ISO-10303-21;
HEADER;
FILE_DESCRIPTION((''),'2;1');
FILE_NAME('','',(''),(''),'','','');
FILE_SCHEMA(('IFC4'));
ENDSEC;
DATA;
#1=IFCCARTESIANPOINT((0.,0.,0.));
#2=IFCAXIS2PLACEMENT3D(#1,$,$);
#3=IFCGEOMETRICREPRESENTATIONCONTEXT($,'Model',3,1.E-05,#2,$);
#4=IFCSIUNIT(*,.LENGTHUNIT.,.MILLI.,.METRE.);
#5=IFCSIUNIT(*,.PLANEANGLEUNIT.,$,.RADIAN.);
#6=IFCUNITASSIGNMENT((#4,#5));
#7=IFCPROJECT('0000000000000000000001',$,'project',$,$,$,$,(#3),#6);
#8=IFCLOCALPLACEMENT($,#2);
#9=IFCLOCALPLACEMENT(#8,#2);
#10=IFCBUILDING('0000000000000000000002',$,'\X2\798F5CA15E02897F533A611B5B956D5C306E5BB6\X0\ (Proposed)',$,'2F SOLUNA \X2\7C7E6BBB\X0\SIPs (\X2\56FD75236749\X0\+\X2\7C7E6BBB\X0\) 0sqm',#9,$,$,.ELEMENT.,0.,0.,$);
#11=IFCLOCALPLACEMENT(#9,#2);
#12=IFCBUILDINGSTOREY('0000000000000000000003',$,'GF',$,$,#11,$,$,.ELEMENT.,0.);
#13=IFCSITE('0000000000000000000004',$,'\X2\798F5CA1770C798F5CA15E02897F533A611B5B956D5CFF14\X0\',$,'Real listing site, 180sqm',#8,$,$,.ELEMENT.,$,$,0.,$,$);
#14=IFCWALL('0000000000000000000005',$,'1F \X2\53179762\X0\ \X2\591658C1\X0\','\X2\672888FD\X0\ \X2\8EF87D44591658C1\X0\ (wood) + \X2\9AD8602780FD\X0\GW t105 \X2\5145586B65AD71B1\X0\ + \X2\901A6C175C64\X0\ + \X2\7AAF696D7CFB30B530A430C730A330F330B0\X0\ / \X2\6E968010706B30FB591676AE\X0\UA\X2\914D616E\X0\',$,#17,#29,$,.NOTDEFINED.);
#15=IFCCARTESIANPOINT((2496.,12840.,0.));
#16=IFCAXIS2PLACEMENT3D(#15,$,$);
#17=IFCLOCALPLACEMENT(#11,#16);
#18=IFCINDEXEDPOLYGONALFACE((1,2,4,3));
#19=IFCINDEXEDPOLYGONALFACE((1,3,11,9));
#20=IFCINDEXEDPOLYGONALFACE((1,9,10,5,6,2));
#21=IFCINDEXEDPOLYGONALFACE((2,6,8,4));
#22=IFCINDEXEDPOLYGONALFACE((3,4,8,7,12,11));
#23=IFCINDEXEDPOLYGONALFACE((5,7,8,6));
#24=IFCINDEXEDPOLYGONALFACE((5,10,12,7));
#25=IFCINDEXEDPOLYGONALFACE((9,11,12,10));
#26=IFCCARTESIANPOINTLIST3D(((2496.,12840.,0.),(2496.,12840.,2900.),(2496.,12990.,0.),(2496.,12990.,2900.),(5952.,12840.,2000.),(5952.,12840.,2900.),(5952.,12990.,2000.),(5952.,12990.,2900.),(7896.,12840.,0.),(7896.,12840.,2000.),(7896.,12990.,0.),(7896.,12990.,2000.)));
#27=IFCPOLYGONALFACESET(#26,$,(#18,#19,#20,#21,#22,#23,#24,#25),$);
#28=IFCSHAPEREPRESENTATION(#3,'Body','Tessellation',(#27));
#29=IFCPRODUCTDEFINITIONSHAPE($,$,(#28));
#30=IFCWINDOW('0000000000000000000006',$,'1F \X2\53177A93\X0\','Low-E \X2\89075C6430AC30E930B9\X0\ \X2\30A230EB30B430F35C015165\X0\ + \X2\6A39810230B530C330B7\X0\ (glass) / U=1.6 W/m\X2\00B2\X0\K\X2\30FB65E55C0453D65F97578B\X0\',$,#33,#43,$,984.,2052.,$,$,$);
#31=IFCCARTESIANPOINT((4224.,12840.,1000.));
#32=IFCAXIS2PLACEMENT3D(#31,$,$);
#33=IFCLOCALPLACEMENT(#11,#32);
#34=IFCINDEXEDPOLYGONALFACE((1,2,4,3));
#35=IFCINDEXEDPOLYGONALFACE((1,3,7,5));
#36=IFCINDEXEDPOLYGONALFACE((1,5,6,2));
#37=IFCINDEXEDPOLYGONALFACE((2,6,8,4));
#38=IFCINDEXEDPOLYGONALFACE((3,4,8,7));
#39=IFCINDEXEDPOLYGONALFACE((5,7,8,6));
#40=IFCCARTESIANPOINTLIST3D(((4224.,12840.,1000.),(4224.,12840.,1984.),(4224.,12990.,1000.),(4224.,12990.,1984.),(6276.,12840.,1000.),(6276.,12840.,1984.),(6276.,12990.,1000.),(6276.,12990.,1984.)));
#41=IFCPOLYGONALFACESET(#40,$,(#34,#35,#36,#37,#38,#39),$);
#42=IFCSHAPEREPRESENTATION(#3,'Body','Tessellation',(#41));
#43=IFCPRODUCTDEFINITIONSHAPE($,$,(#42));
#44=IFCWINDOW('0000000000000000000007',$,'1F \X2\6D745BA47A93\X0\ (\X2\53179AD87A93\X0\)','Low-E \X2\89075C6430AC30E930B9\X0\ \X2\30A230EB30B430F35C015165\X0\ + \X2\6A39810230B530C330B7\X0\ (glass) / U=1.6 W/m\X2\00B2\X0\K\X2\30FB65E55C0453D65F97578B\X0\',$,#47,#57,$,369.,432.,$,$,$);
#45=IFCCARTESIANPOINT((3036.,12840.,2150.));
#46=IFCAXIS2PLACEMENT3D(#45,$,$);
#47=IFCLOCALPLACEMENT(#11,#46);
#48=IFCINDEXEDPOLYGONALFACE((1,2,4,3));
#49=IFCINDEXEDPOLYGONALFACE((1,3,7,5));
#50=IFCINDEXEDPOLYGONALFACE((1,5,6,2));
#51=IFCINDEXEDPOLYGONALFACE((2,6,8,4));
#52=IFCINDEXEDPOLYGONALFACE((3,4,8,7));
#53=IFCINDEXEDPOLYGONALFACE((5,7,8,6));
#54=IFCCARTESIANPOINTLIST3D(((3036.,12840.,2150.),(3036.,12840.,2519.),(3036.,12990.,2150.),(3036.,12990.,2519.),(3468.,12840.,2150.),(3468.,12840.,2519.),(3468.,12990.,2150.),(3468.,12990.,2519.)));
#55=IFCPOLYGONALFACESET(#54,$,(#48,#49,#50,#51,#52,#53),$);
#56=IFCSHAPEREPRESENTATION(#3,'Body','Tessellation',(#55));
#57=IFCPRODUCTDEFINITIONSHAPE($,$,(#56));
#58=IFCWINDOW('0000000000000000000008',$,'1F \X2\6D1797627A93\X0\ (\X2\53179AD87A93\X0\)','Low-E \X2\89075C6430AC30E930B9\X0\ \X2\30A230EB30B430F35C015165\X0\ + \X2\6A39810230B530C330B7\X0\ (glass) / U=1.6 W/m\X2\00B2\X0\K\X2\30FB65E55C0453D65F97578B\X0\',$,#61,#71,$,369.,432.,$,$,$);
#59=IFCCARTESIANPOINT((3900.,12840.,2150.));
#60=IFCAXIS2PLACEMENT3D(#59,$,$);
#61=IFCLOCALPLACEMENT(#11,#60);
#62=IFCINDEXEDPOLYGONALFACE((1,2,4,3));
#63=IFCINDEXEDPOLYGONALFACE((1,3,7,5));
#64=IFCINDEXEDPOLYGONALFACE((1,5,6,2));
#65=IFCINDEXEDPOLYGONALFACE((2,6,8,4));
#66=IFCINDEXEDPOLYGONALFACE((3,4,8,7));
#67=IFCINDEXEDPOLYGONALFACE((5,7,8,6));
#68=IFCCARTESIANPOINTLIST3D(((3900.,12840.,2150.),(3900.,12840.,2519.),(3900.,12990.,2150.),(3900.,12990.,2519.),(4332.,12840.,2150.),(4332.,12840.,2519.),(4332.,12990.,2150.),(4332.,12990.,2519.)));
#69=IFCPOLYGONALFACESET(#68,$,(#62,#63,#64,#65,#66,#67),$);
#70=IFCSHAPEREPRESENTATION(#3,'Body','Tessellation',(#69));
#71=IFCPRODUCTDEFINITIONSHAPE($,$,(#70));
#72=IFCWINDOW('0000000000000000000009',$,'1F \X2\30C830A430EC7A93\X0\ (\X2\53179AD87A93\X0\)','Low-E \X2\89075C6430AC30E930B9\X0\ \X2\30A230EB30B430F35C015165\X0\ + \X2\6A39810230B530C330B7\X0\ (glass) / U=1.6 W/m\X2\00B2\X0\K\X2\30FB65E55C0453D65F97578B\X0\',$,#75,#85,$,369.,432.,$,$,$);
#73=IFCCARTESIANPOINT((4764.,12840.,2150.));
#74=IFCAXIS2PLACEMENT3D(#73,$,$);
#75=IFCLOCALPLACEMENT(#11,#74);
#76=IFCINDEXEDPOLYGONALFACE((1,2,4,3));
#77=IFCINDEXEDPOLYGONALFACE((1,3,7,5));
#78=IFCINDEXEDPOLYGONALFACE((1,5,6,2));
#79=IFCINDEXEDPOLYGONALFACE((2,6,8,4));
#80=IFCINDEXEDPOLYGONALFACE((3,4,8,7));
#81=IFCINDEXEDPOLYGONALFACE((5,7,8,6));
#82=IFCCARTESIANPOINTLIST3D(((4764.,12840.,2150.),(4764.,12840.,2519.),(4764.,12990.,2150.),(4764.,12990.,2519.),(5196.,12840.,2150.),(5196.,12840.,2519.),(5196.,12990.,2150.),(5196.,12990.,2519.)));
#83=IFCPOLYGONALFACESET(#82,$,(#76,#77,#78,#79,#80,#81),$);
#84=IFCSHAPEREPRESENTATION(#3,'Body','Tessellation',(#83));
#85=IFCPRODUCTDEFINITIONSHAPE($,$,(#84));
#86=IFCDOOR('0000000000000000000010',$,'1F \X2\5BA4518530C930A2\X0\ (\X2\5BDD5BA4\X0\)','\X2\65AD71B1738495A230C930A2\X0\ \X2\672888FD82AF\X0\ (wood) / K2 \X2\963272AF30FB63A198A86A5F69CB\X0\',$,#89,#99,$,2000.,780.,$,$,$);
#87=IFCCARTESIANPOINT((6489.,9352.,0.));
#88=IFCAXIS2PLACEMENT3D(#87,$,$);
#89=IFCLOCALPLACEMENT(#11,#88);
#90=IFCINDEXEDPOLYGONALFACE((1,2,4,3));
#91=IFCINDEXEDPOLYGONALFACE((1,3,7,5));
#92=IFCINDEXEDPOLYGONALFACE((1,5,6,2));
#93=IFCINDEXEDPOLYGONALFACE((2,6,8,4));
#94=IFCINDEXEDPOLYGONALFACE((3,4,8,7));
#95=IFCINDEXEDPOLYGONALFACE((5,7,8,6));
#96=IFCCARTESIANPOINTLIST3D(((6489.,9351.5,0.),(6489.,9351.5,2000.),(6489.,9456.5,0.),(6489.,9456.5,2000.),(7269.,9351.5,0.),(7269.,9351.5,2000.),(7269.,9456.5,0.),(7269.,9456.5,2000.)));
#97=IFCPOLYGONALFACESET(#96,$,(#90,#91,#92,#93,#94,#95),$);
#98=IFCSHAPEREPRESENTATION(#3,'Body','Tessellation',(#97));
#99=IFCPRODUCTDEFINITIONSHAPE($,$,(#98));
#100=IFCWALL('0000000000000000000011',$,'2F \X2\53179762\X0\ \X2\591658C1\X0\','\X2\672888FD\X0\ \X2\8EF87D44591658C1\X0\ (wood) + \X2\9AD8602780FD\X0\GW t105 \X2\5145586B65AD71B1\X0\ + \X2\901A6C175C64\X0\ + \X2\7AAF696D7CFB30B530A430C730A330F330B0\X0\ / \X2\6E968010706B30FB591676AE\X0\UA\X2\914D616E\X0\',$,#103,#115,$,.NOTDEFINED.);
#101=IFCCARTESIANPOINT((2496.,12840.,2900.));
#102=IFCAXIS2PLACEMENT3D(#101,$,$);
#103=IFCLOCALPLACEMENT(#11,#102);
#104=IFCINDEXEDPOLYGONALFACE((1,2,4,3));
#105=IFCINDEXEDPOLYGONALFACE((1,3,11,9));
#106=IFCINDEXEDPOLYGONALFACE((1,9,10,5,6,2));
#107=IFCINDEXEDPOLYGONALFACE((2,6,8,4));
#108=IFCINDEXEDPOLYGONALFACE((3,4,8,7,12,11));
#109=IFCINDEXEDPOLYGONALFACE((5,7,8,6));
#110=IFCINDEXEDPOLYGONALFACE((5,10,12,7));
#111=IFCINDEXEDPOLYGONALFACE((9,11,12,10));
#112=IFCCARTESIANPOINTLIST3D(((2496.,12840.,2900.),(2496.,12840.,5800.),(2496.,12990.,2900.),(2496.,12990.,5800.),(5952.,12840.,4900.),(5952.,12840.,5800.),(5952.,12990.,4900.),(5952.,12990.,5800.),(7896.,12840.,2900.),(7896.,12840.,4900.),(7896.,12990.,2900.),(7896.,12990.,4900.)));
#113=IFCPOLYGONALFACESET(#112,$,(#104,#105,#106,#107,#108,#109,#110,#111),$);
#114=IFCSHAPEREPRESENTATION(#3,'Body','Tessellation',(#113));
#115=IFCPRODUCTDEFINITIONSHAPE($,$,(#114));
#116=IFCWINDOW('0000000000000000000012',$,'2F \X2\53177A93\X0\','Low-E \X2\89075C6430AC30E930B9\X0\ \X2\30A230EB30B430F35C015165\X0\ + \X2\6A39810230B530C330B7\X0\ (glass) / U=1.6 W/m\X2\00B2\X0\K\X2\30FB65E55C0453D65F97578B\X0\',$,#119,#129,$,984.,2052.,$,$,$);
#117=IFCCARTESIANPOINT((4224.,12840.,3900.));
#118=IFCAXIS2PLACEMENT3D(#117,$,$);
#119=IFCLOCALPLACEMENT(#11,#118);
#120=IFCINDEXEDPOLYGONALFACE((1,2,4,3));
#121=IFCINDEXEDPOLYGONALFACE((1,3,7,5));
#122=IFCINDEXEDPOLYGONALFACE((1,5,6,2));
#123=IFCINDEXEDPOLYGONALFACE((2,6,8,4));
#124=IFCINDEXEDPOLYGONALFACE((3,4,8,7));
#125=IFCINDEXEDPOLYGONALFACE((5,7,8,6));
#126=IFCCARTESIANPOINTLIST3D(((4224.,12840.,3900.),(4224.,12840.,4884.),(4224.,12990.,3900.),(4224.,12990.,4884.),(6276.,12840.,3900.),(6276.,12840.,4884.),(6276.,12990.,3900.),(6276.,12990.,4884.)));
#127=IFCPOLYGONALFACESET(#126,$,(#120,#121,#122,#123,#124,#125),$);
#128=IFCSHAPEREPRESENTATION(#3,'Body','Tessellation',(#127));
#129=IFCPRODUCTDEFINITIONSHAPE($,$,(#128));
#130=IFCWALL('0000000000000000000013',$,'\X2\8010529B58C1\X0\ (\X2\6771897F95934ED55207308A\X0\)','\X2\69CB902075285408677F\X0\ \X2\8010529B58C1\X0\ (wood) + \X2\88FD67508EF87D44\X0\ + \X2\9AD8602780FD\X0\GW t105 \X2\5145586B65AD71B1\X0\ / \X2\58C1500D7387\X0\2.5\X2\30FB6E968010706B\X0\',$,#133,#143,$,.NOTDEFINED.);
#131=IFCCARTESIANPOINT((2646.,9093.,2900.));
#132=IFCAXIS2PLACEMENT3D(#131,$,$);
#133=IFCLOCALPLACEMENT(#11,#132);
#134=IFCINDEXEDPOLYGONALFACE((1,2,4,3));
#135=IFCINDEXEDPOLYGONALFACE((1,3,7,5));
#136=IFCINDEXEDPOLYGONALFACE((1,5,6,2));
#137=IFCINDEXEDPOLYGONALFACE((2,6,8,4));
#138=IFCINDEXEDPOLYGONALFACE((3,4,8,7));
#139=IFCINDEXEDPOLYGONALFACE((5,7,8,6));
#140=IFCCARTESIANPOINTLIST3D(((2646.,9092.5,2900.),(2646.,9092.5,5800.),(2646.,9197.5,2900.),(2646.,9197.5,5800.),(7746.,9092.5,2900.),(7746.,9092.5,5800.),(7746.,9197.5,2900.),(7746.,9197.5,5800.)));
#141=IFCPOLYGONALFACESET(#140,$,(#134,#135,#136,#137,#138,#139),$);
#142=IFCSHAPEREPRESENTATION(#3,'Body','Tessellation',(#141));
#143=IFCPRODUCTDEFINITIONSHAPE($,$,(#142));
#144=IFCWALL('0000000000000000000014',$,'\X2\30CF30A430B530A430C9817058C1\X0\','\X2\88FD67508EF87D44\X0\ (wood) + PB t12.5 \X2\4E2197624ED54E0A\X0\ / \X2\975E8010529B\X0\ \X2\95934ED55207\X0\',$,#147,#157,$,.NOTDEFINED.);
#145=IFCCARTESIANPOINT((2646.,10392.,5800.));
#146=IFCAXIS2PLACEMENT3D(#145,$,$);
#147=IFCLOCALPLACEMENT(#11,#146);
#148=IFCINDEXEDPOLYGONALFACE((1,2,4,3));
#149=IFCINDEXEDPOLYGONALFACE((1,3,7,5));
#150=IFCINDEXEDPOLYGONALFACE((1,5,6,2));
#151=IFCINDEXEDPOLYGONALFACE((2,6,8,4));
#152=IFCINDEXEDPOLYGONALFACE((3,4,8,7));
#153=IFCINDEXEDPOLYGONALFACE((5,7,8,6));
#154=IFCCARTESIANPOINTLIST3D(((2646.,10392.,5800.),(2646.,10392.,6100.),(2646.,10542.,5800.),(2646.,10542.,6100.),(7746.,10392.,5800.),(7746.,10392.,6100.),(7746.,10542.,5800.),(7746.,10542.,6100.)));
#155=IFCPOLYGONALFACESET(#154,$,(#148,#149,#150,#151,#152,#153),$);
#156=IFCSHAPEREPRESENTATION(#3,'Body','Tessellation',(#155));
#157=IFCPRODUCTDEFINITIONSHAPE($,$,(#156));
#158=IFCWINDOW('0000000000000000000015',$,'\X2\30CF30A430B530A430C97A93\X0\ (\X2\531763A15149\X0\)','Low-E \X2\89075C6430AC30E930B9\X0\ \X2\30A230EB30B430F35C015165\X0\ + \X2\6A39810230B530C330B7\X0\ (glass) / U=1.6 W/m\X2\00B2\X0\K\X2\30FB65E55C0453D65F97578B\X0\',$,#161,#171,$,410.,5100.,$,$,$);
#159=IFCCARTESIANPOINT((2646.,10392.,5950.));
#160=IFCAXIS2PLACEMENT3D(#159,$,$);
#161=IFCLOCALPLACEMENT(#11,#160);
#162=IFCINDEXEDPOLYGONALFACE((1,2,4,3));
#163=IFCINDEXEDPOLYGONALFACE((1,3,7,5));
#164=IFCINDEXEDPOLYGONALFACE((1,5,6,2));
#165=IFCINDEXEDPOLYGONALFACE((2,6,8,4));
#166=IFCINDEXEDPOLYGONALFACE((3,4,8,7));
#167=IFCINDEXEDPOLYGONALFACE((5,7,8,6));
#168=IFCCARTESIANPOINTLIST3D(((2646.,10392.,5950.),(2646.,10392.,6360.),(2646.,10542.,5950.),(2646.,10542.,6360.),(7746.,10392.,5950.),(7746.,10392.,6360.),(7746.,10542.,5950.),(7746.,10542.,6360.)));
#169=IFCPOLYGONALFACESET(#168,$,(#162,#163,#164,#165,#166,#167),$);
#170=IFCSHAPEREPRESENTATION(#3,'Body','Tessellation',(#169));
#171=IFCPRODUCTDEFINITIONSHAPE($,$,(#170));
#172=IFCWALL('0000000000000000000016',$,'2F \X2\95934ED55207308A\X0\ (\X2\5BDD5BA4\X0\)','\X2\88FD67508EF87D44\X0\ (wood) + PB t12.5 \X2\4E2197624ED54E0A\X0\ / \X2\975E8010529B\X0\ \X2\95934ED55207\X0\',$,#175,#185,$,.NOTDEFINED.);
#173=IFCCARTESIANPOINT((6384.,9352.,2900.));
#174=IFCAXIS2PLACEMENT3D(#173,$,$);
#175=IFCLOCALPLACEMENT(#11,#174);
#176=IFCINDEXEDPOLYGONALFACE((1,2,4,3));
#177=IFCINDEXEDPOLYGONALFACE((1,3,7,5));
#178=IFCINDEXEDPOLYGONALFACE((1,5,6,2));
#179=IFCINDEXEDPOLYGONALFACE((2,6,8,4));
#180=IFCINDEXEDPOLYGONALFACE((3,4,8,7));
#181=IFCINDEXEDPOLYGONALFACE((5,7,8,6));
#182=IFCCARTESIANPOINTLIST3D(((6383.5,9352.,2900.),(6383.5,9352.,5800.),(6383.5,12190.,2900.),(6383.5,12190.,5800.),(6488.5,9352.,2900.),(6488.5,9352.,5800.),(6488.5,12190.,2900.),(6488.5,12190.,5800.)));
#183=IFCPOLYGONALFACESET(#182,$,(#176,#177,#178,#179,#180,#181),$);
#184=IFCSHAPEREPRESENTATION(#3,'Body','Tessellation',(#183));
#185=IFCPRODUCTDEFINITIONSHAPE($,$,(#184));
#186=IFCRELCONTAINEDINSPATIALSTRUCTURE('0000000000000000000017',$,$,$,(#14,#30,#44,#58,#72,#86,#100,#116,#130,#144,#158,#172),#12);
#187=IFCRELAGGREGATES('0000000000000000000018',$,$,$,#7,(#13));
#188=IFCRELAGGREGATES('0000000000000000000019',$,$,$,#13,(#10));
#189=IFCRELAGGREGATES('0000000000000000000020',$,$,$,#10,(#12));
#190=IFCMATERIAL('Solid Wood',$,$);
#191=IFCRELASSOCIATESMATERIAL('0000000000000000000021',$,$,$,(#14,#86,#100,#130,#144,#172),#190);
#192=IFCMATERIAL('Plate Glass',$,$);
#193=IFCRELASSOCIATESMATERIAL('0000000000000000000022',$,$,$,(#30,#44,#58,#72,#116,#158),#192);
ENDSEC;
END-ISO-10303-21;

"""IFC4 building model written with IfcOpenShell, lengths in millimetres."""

from ifc_helpers import new_model, si_unit, frame, frame_2d, origin, place, context, project, spatial, rectangle, extrude, material, element, fill, save


model = new_model("IFC4")

# Units and contexts
model_context = context("Model", 3, precision=1e-05, world=origin())
ifc_project = project(units=[si_unit("LENGTHUNIT", "METRE", prefix="MILLI"), si_unit("PLANEANGLEUNIT", "RADIAN")], contexts=[model_context])

# Site, building, storey
site_placement = place(None, origin())
site = spatial("IfcSite", under=ifc_project, at=site_placement, Name="福岡県福岡市西区愛宕浜４", ObjectType="Real listing site, 180sqm", CompositionType="ELEMENT", RefElevation=0.0)
building_placement = place(site_placement, origin())
building = spatial("IfcBuilding", under=site, at=building_placement, Name="福岡市西区愛宕浜の家 (Proposed)", ObjectType="2F SOLUNA 籾殻SIPs (国産杉+籾殻) 0sqm", CompositionType="ELEMENT", ElevationOfRefHeight=0.0, ElevationOfTerrain=0.0)
storey_placement = place(building_placement, origin())
storey = spatial("IfcBuildingStorey", under=building, at=storey_placement, Name="GF", CompositionType="ELEMENT", Elevation=0.0)

# Wall, openings, windows
ifc_material_1 = material(Name="Solid Wood")
wall_1_placement = place(storey_placement, frame((2496.0, 12840.0, 0.0)))
wall_1 = element("IfcWall", 1, at=wall_1_placement, inside=storey, material=ifc_material_1, Name="1F 北面 外壁", Description="木製 軸組外壁 (wood) + 高性能GW t105 充填断熱 + 通気層 + 窯業系サイディング / 準耐火・外皮UA配慮", PredefinedType="NOTDEFINED", context=model_context, shape_type="SweptSolid", body=[
    extrude(rectangle(XDim=5400.0, YDim=150.0, at=frame_2d((2700.0, 75.0))), frame((2496.0, 12840.0, 0.0)), (0.0, 0.0, 1.0), 2900.0),
])
opening_1_placement = place(storey_placement, frame((4224.0, 12840.0, 1000.0)))
opening_1 = element("IfcOpeningElement", 2, at=opening_1_placement, cuts=wall_1, PredefinedType="NOTDEFINED", context=model_context, shape_type="SweptSolid", body=[
    extrude(rectangle(XDim=2052.0, YDim=150.0, at=frame_2d((1026.0, 75.0))), frame((4224.0, 12840.0, 1000.0)), (0.0, 0.0, 1.0), 984.0),
])
opening_2_placement = place(storey_placement, frame((3036.0, 12840.0, 2150.0)))
opening_2 = element("IfcOpeningElement", 3, at=opening_2_placement, cuts=wall_1, PredefinedType="NOTDEFINED", context=model_context, shape_type="SweptSolid", body=[
    extrude(rectangle(XDim=432.0, YDim=150.0, at=frame_2d((216.0, 75.0))), frame((3036.0, 12840.0, 2150.0)), (0.0, 0.0, 1.0), 369.0),
])
opening_3_placement = place(storey_placement, frame((3900.0, 12840.0, 2150.0)))
opening_3 = element("IfcOpeningElement", 4, at=opening_3_placement, cuts=wall_1, PredefinedType="NOTDEFINED", context=model_context, shape_type="SweptSolid", body=[
    extrude(rectangle(XDim=432.0, YDim=150.0, at=frame_2d((216.0, 75.0))), frame((3900.0, 12840.0, 2150.0)), (0.0, 0.0, 1.0), 369.0),
])
opening_4_placement = place(storey_placement, frame((4764.0, 12840.0, 2150.0)))
opening_4 = element("IfcOpeningElement", 5, at=opening_4_placement, cuts=wall_1, PredefinedType="NOTDEFINED", context=model_context, shape_type="SweptSolid", body=[
    extrude(rectangle(XDim=432.0, YDim=150.0, at=frame_2d((216.0, 75.0))), frame((4764.0, 12840.0, 2150.0)), (0.0, 0.0, 1.0), 369.0),
])
ifc_material_2 = material(Name="Plate Glass")
window_1_placement = place(storey_placement, frame((4224.0, 12840.0, 1000.0)))
window_1 = element("IfcWindow", 6, at=window_1_placement, inside=storey, material=ifc_material_2, Name="1F 北窓", Description="Low-E 複層ガラス アルゴン封入 + 樹脂サッシ (glass) / U=1.6 W/m²K・日射取得型", OverallHeight=984.0, OverallWidth=2052.0, context=model_context, shape_type="SweptSolid", body=[
    extrude(rectangle(XDim=2052.0, YDim=150.0, at=frame_2d((1026.0, 75.0))), frame((4224.0, 12840.0, 1000.0)), (0.0, 0.0, 1.0), 984.0),
])
fill(opening_1, window_1)
window_2_placement = place(storey_placement, frame((3036.0, 12840.0, 2150.0)))
window_2 = element("IfcWindow", 7, at=window_2_placement, inside=storey, material=ifc_material_2, Name="1F 浴室窓 (北高窓)", Description="Low-E 複層ガラス アルゴン封入 + 樹脂サッシ (glass) / U=1.6 W/m²K・日射取得型", OverallHeight=369.0, OverallWidth=432.0, context=model_context, shape_type="SweptSolid", body=[
    extrude(rectangle(XDim=432.0, YDim=150.0, at=frame_2d((216.0, 75.0))), frame((3036.0, 12840.0, 2150.0)), (0.0, 0.0, 1.0), 369.0),
])
fill(opening_2, window_2)
window_3_placement = place(storey_placement, frame((3900.0, 12840.0, 2150.0)))
window_3 = element("IfcWindow", 8, at=window_3_placement, inside=storey, material=ifc_material_2, Name="1F 洗面窓 (北高窓)", Description="Low-E 複層ガラス アルゴン封入 + 樹脂サッシ (glass) / U=1.6 W/m²K・日射取得型", OverallHeight=369.0, OverallWidth=432.0, context=model_context, shape_type="SweptSolid", body=[
    extrude(rectangle(XDim=432.0, YDim=150.0, at=frame_2d((216.0, 75.0))), frame((3900.0, 12840.0, 2150.0)), (0.0, 0.0, 1.0), 369.0),
])
fill(opening_3, window_3)
window_4_placement = place(storey_placement, frame((4764.0, 12840.0, 2150.0)))
window_4 = element("IfcWindow", 9, at=window_4_placement, inside=storey, material=ifc_material_2, Name="1F トイレ窓 (北高窓)", Description="Low-E 複層ガラス アルゴン封入 + 樹脂サッシ (glass) / U=1.6 W/m²K・日射取得型", OverallHeight=369.0, OverallWidth=432.0, context=model_context, shape_type="SweptSolid", body=[
    extrude(rectangle(XDim=432.0, YDim=150.0, at=frame_2d((216.0, 75.0))), frame((4764.0, 12840.0, 2150.0)), (0.0, 0.0, 1.0), 369.0),
])
fill(opening_4, window_4)

# Door
door_1_placement = place(storey_placement, frame((6489.0, 9352.0, 0.0)))
element("IfcDoor", 10, at=door_1_placement, inside=storey, material=ifc_material_1, Name="1F 室内ドア (寝室)", Description="断熱玄関ドア 木製芯 (wood) / K2 防犯・採風機構", OverallHeight=2000.0, OverallWidth=780.0, context=model_context, shape_type="SweptSolid", body=[
    extrude(rectangle(XDim=780.0, YDim=105.0, at=frame_2d((390.0, 52.0))), frame((6489.0, 9352.0, 0.0)), (0.0, 0.0, 1.0), 2000.0),
])

# Wall, opening, window
wall_2_placement = place(storey_placement, frame((2496.0, 12840.0, 2900.0)))
wall_2 = element("IfcWall", 11, at=wall_2_placement, inside=storey, material=ifc_material_1, Name="2F 北面 外壁", Description="木製 軸組外壁 (wood) + 高性能GW t105 充填断熱 + 通気層 + 窯業系サイディング / 準耐火・外皮UA配慮", PredefinedType="NOTDEFINED", context=model_context, shape_type="SweptSolid", body=[
    extrude(rectangle(XDim=5400.0, YDim=150.0, at=frame_2d((2700.0, 75.0))), frame((2496.0, 12840.0, 2900.0)), (0.0, 0.0, 1.0), 2900.0),
])
opening_5_placement = place(storey_placement, frame((4224.0, 12840.0, 3900.0)))
opening_5 = element("IfcOpeningElement", 12, at=opening_5_placement, cuts=wall_2, PredefinedType="NOTDEFINED", context=model_context, shape_type="SweptSolid", body=[
    extrude(rectangle(XDim=2052.0, YDim=150.0, at=frame_2d((1026.0, 75.0))), frame((4224.0, 12840.0, 3900.0)), (0.0, 0.0, 1.0), 984.0),
])
window_5_placement = place(storey_placement, frame((4224.0, 12840.0, 3900.0)))
window_5 = element("IfcWindow", 13, at=window_5_placement, inside=storey, material=ifc_material_2, Name="2F 北窓", Description="Low-E 複層ガラス アルゴン封入 + 樹脂サッシ (glass) / U=1.6 W/m²K・日射取得型", OverallHeight=984.0, OverallWidth=2052.0, context=model_context, shape_type="SweptSolid", body=[
    extrude(rectangle(XDim=2052.0, YDim=150.0, at=frame_2d((1026.0, 75.0))), frame((4224.0, 12840.0, 3900.0)), (0.0, 0.0, 1.0), 984.0),
])
fill(opening_5, window_5)

# Wall
wall_3_placement = place(storey_placement, frame((2646.0, 9093.0, 2900.0)))
element("IfcWall", 14, at=wall_3_placement, inside=storey, material=ifc_material_1, Name="耐力壁 (東西間仕切り)", Description="構造用合板 耐力壁 (wood) + 製材軸組 + 高性能GW t105 充填断熱 / 壁倍率2.5・準耐火", PredefinedType="NOTDEFINED", context=model_context, shape_type="SweptSolid", body=[
    extrude(rectangle(XDim=5100.0, YDim=105.0, at=frame_2d((2550.0, 52.0))), frame((2646.0, 9093.0, 2900.0)), (0.0, 0.0, 1.0), 2900.0),
])

# Wall, opening, window
wall_4_placement = place(storey_placement, frame((2646.0, 10392.0, 5800.0)))
wall_4 = element("IfcWall", 15, at=wall_4_placement, inside=storey, material=ifc_material_1, Name="ハイサイド腰壁", Description="製材軸組 (wood) + PB t12.5 両面仕上 / 非耐力 間仕切", PredefinedType="NOTDEFINED", context=model_context, shape_type="SweptSolid", body=[
    extrude(rectangle(XDim=5100.0, YDim=150.0, at=frame_2d((2550.0, 75.0))), frame((2646.0, 10392.0, 5800.0)), (0.0, 0.0, 1.0), 700.0),
])
opening_6_placement = place(storey_placement, frame((2646.0, 10392.0, 5950.0)))
opening_6 = element("IfcOpeningElement", 16, at=opening_6_placement, cuts=wall_4, PredefinedType="NOTDEFINED", context=model_context, shape_type="SweptSolid", body=[
    extrude(rectangle(XDim=5100.0, YDim=150.0, at=frame_2d((2550.0, 75.0))), frame((2646.0, 10392.0, 5950.0)), (0.0, 0.0, 1.0), 410.0),
])
window_6_placement = place(storey_placement, frame((2646.0, 10392.0, 5950.0)))
window_6 = element("IfcWindow", 17, at=window_6_placement, inside=storey, material=ifc_material_2, Name="ハイサイド窓 (北採光)", Description="Low-E 複層ガラス アルゴン封入 + 樹脂サッシ (glass) / U=1.6 W/m²K・日射取得型", OverallHeight=410.0, OverallWidth=5100.0, context=model_context, shape_type="SweptSolid", body=[
    extrude(rectangle(XDim=5100.0, YDim=150.0, at=frame_2d((2550.0, 75.0))), frame((2646.0, 10392.0, 5950.0)), (0.0, 0.0, 1.0), 410.0),
])
fill(opening_6, window_6)

# Wall
wall_5_placement = place(storey_placement, frame((6384.0, 9352.0, 2900.0)))
element("IfcWall", 18, at=wall_5_placement, inside=storey, material=ifc_material_1, Name="2F 間仕切り (寝室)", Description="製材軸組 (wood) + PB t12.5 両面仕上 / 非耐力 間仕切", PredefinedType="NOTDEFINED", context=model_context, shape_type="SweptSolid", body=[
    extrude(rectangle(XDim=105.0, YDim=2838.0, at=frame_2d((52.0, 1419.0))), frame((6384.0, 9352.0, 2900.0)), (0.0, 0.0, 1.0), 2900.0),
])

save(model, "model.ifc")
